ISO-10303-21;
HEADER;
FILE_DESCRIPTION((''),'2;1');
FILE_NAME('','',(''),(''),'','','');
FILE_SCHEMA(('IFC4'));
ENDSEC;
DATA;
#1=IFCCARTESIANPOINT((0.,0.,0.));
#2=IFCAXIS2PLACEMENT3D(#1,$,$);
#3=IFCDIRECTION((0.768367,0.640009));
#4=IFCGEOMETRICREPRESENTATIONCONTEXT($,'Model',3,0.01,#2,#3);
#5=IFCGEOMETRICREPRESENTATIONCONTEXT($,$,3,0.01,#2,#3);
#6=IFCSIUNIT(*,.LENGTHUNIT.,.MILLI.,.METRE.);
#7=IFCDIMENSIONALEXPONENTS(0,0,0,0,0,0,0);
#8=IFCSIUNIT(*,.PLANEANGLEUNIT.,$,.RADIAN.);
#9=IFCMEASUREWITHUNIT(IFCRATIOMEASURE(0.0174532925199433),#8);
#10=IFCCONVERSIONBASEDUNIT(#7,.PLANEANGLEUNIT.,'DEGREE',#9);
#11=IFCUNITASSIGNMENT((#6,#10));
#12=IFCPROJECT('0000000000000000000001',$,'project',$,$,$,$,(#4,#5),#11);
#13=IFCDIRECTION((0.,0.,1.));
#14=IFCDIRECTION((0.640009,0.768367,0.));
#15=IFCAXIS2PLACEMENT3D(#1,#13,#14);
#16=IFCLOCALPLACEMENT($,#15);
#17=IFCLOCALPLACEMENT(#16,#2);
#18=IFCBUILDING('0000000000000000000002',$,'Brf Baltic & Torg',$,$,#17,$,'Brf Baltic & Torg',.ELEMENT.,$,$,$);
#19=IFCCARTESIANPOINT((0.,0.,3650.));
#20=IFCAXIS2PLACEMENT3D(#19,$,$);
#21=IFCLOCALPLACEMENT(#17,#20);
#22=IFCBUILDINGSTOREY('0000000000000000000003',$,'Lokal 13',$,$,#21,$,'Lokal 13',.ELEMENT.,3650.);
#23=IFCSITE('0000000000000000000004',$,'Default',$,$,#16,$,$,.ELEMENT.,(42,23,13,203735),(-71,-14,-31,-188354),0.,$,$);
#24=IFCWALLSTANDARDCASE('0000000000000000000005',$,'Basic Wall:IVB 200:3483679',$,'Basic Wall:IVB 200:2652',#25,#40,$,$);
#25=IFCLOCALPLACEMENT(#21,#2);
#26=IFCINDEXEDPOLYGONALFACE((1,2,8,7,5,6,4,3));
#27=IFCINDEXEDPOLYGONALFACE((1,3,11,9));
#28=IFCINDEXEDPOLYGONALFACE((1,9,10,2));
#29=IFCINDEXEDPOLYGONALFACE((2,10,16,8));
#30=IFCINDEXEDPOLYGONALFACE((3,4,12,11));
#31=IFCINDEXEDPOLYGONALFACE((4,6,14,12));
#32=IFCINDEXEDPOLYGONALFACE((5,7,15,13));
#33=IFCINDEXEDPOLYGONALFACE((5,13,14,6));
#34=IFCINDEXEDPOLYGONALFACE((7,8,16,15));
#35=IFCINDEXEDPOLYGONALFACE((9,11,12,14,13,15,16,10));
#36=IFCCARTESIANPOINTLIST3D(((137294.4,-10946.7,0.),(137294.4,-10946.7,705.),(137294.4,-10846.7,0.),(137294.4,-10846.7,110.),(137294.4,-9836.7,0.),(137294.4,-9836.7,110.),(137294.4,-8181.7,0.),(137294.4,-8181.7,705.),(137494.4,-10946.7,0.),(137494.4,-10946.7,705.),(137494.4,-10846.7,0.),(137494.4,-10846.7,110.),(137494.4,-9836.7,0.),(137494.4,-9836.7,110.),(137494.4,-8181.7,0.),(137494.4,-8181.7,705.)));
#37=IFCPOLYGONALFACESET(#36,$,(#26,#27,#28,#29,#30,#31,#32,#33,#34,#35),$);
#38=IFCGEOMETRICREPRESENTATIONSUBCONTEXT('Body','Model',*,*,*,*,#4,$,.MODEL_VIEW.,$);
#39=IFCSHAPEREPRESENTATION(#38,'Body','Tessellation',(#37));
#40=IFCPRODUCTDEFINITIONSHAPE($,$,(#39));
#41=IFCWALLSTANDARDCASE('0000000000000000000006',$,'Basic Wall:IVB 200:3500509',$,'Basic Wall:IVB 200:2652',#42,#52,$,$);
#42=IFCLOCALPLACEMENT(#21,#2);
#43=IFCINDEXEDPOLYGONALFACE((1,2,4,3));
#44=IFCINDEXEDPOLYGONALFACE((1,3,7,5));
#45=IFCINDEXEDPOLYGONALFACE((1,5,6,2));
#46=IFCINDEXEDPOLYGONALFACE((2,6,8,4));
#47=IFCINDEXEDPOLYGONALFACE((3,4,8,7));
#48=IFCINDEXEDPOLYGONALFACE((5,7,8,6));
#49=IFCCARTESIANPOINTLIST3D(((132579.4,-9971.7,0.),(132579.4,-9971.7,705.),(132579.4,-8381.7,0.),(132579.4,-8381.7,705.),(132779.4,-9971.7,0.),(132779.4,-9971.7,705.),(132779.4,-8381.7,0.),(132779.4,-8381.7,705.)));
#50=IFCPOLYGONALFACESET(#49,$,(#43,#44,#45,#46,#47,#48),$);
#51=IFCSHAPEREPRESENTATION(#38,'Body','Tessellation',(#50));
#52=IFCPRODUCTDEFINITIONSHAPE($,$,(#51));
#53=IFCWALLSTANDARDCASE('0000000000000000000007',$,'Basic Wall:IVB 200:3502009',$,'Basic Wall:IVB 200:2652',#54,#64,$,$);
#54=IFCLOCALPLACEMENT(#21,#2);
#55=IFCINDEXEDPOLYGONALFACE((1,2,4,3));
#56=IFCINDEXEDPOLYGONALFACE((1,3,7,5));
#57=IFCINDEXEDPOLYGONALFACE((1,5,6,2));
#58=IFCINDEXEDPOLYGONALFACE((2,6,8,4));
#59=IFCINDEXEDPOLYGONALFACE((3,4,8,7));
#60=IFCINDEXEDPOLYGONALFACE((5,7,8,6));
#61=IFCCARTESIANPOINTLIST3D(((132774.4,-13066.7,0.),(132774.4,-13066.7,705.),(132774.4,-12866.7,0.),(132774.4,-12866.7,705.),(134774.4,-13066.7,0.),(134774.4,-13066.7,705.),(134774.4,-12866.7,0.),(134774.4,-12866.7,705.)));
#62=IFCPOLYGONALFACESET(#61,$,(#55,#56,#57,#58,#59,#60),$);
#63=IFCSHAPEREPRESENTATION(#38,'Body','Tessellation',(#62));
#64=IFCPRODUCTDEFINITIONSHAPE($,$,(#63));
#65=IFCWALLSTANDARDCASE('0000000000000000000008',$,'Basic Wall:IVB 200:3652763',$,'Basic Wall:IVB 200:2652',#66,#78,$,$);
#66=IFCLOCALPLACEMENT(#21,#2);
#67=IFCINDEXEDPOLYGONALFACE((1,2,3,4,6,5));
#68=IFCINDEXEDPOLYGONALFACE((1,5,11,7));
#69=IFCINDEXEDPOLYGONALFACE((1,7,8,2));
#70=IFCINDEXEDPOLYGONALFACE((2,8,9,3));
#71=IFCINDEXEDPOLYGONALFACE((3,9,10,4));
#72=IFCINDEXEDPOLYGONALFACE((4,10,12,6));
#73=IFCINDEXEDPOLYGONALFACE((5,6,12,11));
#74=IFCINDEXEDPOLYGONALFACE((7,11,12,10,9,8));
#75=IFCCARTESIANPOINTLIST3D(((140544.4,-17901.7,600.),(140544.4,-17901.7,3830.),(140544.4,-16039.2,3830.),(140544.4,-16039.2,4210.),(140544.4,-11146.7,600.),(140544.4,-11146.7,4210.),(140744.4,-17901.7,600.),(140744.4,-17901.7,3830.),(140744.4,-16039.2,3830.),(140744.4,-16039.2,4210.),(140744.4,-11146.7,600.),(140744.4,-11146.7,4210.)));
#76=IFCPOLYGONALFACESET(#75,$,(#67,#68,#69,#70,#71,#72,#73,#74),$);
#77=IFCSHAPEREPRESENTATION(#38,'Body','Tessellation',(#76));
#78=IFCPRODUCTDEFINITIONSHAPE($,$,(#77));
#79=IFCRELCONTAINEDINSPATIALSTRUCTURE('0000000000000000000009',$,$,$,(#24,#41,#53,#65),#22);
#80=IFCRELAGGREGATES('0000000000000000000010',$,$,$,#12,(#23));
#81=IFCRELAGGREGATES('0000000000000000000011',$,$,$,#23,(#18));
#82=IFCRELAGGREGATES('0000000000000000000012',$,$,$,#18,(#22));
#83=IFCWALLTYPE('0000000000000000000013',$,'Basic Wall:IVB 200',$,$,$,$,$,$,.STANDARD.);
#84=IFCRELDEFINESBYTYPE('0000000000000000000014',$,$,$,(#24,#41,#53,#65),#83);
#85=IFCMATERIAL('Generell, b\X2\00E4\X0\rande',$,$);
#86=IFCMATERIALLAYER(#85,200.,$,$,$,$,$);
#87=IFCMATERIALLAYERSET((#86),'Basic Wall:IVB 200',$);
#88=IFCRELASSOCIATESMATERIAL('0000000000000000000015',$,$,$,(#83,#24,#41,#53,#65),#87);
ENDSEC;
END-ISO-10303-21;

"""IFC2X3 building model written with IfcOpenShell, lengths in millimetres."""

from ifc_helpers import new_model, entity, si_unit, converted_unit, direction, frame, frame_2d, origin, place, context, subcontext, project, spatial, polyline, rectangle, extrude, clip, halfspace, bounded_halfspace, material, layer, layer_set, layer_usage, type_object, element, save


model = new_model("IFC2X3")

# Units and contexts
model_context = context("Model", 3, precision=0.01, world=origin(), true_north=direction((0.768367, 0.640009)))
context_of_model = context(None, 3, precision=0.01, world=origin(), true_north=direction((0.768367, 0.640009)))
body_context = subcontext(model_context, "Body", "Model", "MODEL_VIEW")
ifc_project = project(units=[si_unit("LENGTHUNIT", "METRE", prefix="MILLI"), converted_unit("PLANEANGLEUNIT", "DEGREE", entity("IfcRatioMeasure", 0.0174532925199433), si_unit("PLANEANGLEUNIT", "RADIAN"), dimensions=[0, 0, 0, 0, 0, 0, 0])], contexts=[model_context, context_of_model])

# Site, building, storey
site_placement = place(None, frame((0.0, 0.0, 0.0), z_axis=(0.0, 0.0, 1.0), x_axis=(0.640009, 0.768367, 0.0)))
site = spatial("IfcSite", under=ifc_project, at=site_placement, Name="Default", CompositionType="ELEMENT", RefLatitude=(42, 23, 13, 203735), RefLongitude=(-71, -14, -31, -188354), RefElevation=0.0)
building_placement = place(site_placement, origin())
building = spatial("IfcBuilding", under=site, at=building_placement, Name="Brf Baltic & Torg", LongName="Brf Baltic & Torg", CompositionType="ELEMENT")
storey_placement = place(building_placement, frame((0.0, 0.0, 3650.0)))
storey = spatial("IfcBuildingStorey", under=building, at=storey_placement, Name="Lokal 13", LongName="Lokal 13", CompositionType="ELEMENT", Elevation=3650.0)

# Shared definitions
ifc_material_1 = material(Name="Generell, bärande")
ifc_layer_1 = layer(ifc_material_1, 200.0)
ifc_layer_set_1 = layer_set([ifc_layer_1], Name="Basic Wall:IVB 200")
wall_type_1 = type_object("IfcWallType", Name="Basic Wall:IVB 200", PredefinedType="STANDARD", material=ifc_layer_set_1)

# Wall, opening
ifc_layer_usage_1 = layer_usage(ifc_layer_set_1, "AXIS2", "NEGATIVE", 100.0)
wall_1_placement = place(storey_placement, frame((137394.4, -8181.7, 0.0), z_axis=(0.0, 0.0, 1.0), x_axis=(0.0, -1.0, 0.0)))
wall_1 = element("IfcWallStandardCase", 1, at=wall_1_placement, inside=storey, type_object=wall_type_1, material=ifc_layer_usage_1, Name="Basic Wall:IVB 200:3483679", ObjectType="Basic Wall:IVB 200:2652", context=body_context, shape_type="Clipping", body=[
    clip(clip(extrude(rectangle(XDim=2765.0, YDim=200.0, at=frame_2d((1382.5, 0.0), x_axis=(-1.0, 0.0))), origin(), (0.0, 0.0, 1.0), 705.0), bounded_halfspace(frame((0.0, -100.0, 705.0), z_axis=(0.0, 0.0, -1.0), x_axis=(-1.0, 0.0, 0.0)), True, frame((0.0, -100.0, 705.0)), polyline([(0.0, 0.0), (200.0, 0.0), (200.0, 200.0), (0.0, 200.0), (0.0, 0.0)]))), halfspace(frame((0.0, 0.0, -2000.0)), True)),
])
opening_1_placement = place(wall_1_placement, frame((-8181.7, -137394.4, -2000.0), z_axis=(0.0, 0.0, 1.0), x_axis=(0.0, 1.0, 0.0)))
element("IfcOpeningElement", 2, at=opening_1_placement, cuts=wall_1, ObjectType="Opening", context=body_context, shape_type="SweptSolid", body=[
    extrude(rectangle(XDim=2110.0, YDim=1010.0, at=frame_2d((0.0, 0.0), x_axis=(0.0, 1.0))), frame((135770.4, -10341.7, 1055.0), z_axis=(1.0, 0.0, 0.0), x_axis=(0.0, 1.0, 0.0)), (0.0, 0.0, 1.0), 3048.0),
])

# Walls
ifc_layer_usage_2 = layer_usage(ifc_layer_set_1, "AXIS2", "NEGATIVE", 100.0)
wall_2_placement = place(storey_placement, frame((132679.4, -9971.7, 0.0), z_axis=(0.0, 0.0, 1.0), x_axis=(0.0, 1.0, 0.0)))
element("IfcWallStandardCase", 3, at=wall_2_placement, inside=storey, type_object=wall_type_1, material=ifc_layer_usage_2, Name="Basic Wall:IVB 200:3500509", ObjectType="Basic Wall:IVB 200:2652", context=body_context, shape_type="Clipping", body=[
    clip(clip(extrude(rectangle(XDim=1590.0, YDim=200.0, at=frame_2d((795.0, 0.0), x_axis=(-1.0, 0.0))), origin(), (0.0, 0.0, 1.0), 705.0), bounded_halfspace(frame((0.0, -100.0, 705.0), z_axis=(0.0, 0.0, -1.0), x_axis=(1.0, 0.0, 0.0)), True, frame((0.0, -100.0, 705.0)), polyline([(0.0, 0.0), (1590.0, 0.0), (1590.0, 200.0), (0.0, 200.0), (0.0, 0.0)]))), halfspace(frame((0.0, 0.0, -2000.0)), True)),
])
ifc_layer_usage_3 = layer_usage(ifc_layer_set_1, "AXIS2", "NEGATIVE", 100.0)
wall_3_placement = place(storey_placement, frame((134774.4, -12966.7, 0.0), z_axis=(0.0, 0.0, 1.0), x_axis=(-1.0, 0.0, 0.0)))
element("IfcWallStandardCase", 4, at=wall_3_placement, inside=storey, type_object=wall_type_1, material=ifc_layer_usage_3, Name="Basic Wall:IVB 200:3502009", ObjectType="Basic Wall:IVB 200:2652", context=body_context, shape_type="Clipping", body=[
    clip(clip(extrude(rectangle(XDim=2000.0, YDim=200.0, at=frame_2d((1000.0, 0.0), x_axis=(-1.0, 0.0))), origin(), (0.0, 0.0, 1.0), 705.0), bounded_halfspace(frame((0.0, -100.0, 705.0), z_axis=(0.0, 0.0, -1.0), x_axis=(0.0, -1.0, 0.0)), True, frame((0.0, -100.0, 705.0)), polyline([(0.0, 0.0), (1800.0, 0.0), (2000.0, 0.0), (2000.0, 200.0), (0.0, 200.0), (0.0, 0.0)]))), halfspace(frame((0.0, 0.0, -2000.0)), True)),
])

# Wall, opening
ifc_layer_usage_4 = layer_usage(ifc_layer_set_1, "AXIS2", "NEGATIVE", 100.0)
wall_4_placement = place(storey_placement, frame((140644.4, -11146.7, 600.0), z_axis=(0.0, 0.0, 1.0), x_axis=(0.0, -1.0, 0.0)))
wall_4 = element("IfcWallStandardCase", 5, at=wall_4_placement, inside=storey, type_object=wall_type_1, material=ifc_layer_usage_4, Name="Basic Wall:IVB 200:3652763", ObjectType="Basic Wall:IVB 200:2652", context=body_context, shape_type="SweptSolid", body=[
    extrude(rectangle(XDim=6755.0, YDim=200.0, at=frame_2d((3377.5, 0.0), x_axis=(-1.0, 0.0))), origin(), (0.0, 0.0, 1.0), 3610.0),
])
opening_2_placement = place(wall_4_placement, origin())
element("IfcOpeningElement", 6, at=opening_2_placement, cuts=wall_4, ObjectType="Opening", context=body_context, shape_type="SweptSolid", body=[
    extrude(rectangle(XDim=380.0, YDim=2040.0, at=frame_2d((0.0, 0.0), x_axis=(1.0, 0.0))), frame((5912.5, 100.0, 3420.0), z_axis=(0.0, -1.0, 0.0), x_axis=(0.0, 0.0, 1.0)), (0.0, 0.0, 1.0), 200.0),
])

save(model, "model.ifc")
